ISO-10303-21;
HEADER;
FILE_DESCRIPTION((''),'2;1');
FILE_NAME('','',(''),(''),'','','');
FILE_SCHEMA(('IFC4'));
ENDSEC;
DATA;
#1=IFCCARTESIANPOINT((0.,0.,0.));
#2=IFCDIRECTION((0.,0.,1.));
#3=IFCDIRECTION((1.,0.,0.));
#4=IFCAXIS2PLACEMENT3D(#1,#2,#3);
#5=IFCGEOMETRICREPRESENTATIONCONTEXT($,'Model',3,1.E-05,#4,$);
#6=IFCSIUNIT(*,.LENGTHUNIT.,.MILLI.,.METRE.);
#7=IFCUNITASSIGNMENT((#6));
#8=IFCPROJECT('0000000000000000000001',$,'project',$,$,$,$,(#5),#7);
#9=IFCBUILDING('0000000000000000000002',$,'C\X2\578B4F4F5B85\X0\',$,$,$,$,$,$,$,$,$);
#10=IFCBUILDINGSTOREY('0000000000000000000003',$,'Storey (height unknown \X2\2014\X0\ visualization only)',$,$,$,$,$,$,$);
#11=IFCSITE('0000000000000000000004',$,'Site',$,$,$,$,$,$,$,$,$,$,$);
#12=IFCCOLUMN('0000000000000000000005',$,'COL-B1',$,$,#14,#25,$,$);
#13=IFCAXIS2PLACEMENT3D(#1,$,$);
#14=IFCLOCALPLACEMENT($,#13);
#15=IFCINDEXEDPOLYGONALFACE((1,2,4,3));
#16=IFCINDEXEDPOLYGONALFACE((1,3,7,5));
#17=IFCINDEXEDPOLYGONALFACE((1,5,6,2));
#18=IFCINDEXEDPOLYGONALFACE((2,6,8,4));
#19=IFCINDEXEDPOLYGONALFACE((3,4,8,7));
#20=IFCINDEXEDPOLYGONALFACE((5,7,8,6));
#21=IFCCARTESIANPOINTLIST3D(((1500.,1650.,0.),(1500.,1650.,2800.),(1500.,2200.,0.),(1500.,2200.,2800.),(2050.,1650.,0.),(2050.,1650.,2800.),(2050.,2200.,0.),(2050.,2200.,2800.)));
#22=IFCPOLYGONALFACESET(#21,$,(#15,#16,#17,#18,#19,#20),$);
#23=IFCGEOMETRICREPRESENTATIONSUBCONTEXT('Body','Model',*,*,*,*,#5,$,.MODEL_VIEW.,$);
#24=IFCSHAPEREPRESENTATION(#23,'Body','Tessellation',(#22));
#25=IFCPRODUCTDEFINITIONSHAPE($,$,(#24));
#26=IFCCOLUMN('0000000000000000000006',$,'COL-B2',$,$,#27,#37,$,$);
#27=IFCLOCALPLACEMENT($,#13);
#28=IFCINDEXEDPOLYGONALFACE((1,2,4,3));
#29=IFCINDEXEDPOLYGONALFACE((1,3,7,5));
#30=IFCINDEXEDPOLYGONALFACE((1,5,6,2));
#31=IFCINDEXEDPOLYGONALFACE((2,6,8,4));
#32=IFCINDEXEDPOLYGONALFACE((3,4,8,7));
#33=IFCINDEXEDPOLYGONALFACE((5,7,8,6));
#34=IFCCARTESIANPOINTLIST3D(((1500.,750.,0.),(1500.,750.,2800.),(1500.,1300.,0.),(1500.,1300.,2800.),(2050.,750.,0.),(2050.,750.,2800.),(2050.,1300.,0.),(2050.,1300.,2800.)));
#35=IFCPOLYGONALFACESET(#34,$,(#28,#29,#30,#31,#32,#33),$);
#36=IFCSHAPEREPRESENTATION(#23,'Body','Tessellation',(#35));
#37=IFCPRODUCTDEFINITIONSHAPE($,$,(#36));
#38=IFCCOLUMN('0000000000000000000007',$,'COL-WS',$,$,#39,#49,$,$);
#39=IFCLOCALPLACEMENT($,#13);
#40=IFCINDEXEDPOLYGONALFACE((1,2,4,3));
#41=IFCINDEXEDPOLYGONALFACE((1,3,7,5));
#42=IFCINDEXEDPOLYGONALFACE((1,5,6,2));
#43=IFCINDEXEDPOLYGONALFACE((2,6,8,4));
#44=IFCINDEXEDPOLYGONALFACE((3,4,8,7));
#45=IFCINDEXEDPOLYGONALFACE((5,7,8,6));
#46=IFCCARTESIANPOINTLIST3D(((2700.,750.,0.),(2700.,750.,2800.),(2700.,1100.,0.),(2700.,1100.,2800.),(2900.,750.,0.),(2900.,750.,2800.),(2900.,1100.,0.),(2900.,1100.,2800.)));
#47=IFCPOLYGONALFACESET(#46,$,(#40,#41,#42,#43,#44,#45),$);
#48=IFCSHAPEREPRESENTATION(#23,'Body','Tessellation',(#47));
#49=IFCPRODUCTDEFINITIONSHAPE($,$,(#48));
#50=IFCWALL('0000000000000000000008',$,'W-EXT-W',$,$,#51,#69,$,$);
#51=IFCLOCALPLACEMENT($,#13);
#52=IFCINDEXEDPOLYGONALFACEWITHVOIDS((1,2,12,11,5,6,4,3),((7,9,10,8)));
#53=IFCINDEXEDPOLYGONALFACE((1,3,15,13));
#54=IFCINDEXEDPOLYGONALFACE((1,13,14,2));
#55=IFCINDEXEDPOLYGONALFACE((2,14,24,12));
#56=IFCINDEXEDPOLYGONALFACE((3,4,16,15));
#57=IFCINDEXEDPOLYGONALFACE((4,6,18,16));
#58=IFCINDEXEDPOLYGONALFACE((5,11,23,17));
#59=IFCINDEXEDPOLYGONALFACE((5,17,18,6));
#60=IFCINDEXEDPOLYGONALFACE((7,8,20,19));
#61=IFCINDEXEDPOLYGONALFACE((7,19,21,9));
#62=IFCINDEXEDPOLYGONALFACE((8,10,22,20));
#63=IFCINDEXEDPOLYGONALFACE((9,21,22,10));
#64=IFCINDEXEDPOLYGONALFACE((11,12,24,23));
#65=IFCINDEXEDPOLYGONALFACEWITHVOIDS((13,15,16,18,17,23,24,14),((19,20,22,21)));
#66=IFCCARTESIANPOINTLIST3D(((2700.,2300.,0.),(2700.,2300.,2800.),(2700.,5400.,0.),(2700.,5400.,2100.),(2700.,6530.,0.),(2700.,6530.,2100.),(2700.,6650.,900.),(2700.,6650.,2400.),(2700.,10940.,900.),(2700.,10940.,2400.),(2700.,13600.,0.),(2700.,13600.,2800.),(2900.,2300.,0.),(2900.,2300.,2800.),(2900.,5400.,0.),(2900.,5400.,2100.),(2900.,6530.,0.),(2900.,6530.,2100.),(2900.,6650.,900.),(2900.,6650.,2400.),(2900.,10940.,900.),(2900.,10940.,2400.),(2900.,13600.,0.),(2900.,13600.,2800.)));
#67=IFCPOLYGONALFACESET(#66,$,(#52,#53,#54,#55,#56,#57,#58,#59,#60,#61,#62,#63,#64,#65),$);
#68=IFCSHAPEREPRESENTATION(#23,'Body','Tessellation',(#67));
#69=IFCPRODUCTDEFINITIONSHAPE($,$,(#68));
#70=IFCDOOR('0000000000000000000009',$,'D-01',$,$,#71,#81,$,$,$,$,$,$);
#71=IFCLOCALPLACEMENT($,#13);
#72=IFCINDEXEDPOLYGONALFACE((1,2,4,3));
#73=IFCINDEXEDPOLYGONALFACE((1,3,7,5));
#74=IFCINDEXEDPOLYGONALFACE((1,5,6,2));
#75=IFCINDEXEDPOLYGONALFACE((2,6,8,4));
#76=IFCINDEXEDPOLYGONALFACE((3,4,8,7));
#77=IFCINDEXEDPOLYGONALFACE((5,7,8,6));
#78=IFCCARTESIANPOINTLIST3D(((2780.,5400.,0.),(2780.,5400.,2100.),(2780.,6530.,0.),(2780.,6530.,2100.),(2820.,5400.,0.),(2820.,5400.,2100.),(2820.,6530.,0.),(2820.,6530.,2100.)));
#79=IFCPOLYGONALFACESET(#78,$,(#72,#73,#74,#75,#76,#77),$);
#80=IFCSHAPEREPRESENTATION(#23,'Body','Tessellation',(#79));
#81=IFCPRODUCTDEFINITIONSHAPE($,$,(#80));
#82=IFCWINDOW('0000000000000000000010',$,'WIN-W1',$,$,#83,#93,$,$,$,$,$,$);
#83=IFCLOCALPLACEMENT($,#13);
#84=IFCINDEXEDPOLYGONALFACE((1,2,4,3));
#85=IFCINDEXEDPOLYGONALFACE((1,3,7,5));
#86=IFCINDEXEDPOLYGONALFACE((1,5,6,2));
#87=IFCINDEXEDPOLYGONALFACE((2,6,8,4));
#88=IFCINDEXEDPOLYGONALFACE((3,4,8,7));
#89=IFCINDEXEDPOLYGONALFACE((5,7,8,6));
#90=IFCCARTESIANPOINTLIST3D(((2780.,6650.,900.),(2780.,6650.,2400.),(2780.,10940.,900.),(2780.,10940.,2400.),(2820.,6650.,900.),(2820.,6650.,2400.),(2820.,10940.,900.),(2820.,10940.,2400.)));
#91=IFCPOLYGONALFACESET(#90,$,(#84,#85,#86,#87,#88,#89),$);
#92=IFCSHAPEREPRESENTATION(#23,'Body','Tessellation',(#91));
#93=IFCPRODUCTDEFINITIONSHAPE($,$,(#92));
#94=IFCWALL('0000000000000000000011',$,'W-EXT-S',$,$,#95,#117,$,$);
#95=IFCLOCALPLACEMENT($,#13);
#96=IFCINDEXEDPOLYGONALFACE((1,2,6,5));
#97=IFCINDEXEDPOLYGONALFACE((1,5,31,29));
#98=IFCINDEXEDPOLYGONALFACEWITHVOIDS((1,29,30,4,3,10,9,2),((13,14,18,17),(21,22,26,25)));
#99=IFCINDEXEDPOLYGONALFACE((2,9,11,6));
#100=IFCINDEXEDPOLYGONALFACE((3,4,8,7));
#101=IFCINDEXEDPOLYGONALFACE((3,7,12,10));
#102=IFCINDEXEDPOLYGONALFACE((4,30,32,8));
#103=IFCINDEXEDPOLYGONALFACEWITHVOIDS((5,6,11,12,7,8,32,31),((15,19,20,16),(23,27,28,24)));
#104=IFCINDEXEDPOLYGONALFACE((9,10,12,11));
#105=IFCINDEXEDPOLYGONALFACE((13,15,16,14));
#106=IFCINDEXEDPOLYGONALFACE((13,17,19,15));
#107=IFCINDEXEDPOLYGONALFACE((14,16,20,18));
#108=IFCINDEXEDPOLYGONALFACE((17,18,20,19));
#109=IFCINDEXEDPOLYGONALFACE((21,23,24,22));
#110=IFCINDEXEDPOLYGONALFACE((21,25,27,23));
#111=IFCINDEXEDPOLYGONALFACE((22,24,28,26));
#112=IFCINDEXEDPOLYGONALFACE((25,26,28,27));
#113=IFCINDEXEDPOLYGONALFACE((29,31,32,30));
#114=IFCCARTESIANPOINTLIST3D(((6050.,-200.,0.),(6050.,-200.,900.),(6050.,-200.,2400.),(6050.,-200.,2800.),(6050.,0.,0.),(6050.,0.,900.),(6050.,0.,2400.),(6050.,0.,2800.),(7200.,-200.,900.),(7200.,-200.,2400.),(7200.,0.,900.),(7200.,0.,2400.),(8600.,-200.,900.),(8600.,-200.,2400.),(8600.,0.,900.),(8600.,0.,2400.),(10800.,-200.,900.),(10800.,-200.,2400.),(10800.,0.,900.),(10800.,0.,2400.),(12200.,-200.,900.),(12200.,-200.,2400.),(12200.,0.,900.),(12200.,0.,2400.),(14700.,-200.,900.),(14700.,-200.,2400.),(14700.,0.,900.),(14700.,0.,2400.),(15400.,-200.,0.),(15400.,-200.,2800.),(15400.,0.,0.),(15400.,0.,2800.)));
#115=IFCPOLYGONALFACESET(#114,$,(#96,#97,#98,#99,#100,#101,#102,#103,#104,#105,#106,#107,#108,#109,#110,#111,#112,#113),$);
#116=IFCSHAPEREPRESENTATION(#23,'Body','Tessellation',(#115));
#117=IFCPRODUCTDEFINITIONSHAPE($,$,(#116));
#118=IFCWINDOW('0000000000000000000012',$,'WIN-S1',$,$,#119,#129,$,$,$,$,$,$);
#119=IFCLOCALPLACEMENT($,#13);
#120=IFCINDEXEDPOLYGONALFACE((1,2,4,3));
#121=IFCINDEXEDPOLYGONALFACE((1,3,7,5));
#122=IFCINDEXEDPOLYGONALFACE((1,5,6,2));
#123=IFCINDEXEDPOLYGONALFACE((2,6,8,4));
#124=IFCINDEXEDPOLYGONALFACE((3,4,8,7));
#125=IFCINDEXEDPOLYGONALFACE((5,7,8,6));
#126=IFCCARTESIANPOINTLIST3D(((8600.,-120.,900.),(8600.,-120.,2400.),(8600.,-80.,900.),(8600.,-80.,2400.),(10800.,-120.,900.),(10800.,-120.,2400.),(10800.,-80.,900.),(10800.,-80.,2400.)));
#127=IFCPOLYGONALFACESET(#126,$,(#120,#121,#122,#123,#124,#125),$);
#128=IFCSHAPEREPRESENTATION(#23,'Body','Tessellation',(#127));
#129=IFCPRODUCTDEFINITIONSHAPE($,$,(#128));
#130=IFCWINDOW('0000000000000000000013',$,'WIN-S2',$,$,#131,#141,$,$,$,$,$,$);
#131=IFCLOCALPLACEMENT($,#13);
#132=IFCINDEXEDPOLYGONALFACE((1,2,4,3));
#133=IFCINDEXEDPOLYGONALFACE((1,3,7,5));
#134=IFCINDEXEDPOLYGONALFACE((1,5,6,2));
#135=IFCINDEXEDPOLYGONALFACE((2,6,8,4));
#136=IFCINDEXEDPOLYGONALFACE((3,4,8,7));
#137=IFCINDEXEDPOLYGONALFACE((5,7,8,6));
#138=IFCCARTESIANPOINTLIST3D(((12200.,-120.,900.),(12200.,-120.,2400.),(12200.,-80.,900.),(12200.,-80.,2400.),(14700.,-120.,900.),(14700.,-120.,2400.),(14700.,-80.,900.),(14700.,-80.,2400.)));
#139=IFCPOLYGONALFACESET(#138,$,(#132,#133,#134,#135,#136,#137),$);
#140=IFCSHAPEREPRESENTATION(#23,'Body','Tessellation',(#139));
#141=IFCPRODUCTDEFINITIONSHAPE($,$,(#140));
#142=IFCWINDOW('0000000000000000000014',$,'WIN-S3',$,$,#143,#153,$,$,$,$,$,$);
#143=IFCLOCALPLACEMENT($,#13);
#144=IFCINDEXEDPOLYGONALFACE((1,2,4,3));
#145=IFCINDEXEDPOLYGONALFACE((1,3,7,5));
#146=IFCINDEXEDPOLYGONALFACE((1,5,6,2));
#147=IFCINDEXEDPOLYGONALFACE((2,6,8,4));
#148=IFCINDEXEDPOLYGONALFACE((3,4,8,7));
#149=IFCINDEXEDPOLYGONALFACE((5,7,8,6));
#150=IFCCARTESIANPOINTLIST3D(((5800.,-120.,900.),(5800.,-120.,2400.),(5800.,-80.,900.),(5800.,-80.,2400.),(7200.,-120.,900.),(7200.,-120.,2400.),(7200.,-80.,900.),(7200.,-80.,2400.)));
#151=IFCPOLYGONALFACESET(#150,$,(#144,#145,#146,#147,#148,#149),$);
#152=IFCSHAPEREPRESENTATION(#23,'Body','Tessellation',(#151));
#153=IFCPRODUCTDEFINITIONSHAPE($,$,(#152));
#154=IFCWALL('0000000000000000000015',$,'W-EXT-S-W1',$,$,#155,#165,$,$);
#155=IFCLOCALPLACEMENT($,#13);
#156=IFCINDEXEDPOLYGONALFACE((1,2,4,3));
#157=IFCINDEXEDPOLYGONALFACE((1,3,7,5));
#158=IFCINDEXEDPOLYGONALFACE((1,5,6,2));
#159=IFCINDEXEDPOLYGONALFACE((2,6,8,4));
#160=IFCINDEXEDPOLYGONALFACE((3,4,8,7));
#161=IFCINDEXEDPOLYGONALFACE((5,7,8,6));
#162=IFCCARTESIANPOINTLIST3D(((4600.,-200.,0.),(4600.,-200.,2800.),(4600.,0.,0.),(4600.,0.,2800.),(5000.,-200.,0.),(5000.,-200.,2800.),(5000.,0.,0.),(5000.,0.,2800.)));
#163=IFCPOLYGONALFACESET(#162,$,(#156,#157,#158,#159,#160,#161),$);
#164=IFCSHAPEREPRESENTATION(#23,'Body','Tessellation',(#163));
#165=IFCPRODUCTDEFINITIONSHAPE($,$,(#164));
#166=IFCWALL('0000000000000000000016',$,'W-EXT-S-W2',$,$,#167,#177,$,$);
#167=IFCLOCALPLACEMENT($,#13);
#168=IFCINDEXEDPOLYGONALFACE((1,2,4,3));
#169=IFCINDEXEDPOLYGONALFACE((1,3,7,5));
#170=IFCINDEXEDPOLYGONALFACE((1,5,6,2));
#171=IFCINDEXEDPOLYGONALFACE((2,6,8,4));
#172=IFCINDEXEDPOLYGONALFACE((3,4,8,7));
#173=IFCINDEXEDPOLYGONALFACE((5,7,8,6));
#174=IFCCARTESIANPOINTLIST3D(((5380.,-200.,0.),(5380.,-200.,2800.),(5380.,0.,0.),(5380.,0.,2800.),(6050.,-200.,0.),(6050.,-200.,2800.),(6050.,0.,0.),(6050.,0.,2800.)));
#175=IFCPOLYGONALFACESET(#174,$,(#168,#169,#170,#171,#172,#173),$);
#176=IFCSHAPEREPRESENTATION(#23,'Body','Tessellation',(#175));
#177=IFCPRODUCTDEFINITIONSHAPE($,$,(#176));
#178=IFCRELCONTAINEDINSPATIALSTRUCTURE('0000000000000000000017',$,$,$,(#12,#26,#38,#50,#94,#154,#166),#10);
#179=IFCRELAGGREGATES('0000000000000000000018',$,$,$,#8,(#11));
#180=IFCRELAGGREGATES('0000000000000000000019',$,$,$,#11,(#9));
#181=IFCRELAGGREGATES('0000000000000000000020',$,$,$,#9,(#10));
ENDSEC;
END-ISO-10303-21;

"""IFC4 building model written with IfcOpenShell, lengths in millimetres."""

from ifc_helpers import new_model, si_unit, frame, frame_2d, origin_with_axes, place, context, subcontext, project, spatial, rectangle, extrude, element, fill, save


model = new_model("IFC4")

# Units and contexts
model_context = context("Model", 3, precision=1e-05, world=origin_with_axes())
body_context = subcontext(model_context, "Body", "Model", "MODEL_VIEW")
ifc_project = project(units=[si_unit("LENGTHUNIT", "METRE", prefix="MILLI")], contexts=[model_context])

# Site, building, storey
site = spatial("IfcSite", under=ifc_project, Name="Site")
building = spatial("IfcBuilding", under=site, Name="C型住宅")
storey = spatial("IfcBuildingStorey", under=building, Name="Storey (height unknown — visualization only)")

# Columns
for number, where, z_axis, x_axis, name in (
    (1, (1500.0, 1650.0, 0.0), (0.0, 0.0, 1.0), (1.0, 0.0, 0.0), "COL-B1"),
    (2, (1500.0, 750.0, 0.0), (0.0, 0.0, 1.0), (1.0, 0.0, 0.0), "COL-B2"),
):
    element("IfcColumn", number, at=place(None, frame(where, z_axis=z_axis, x_axis=x_axis)), inside=storey, Name=name, context=body_context, shape_type="SweptSolid", body=[
        extrude(rectangle(XDim=550.0, YDim=550.0, at=frame_2d((275.0, 275.0))), origin_with_axes(), (0.0, 0.0, 1.0), 2800.0),
    ])
column_placement = place(None, frame((2700.0, 750.0, 0.0), z_axis=(0.0, 0.0, 1.0), x_axis=(1.0, 0.0, 0.0)))
element("IfcColumn", 3, at=column_placement, inside=storey, Name="COL-WS", context=body_context, shape_type="SweptSolid", body=[
    extrude(rectangle(XDim=200.0, YDim=350.0, at=frame_2d((100.0, 175.0))), origin_with_axes(), (0.0, 0.0, 1.0), 2800.0),
])

# Wall, openings, door, window
wall_1_placement = place(None, frame((2700.0, 2300.0, 0.0), z_axis=(0.0, 0.0, 1.0), x_axis=(1.0, 0.0, 0.0)))
wall_1 = element("IfcWall", 4, at=wall_1_placement, inside=storey, Name="W-EXT-W", context=body_context, shape_type="SweptSolid", body=[
    extrude(rectangle(XDim=200.0, YDim=11300.0, at=frame_2d((100.0, 5650.0))), origin_with_axes(), (0.0, 0.0, 1.0), 2800.0),
])
opening_1_placement = place(wall_1_placement, frame((0.0, 3100.0, 0.0)))
opening_1 = element("IfcOpeningElement", 5, at=opening_1_placement, cuts=wall_1, context=body_context, shape_type="SweptSolid", body=[
    extrude(rectangle(XDim=200.0, YDim=1130.0, at=frame_2d((100.0, 565.0))), origin_with_axes(), (0.0, 0.0, 1.0), 2100.0),
])
opening_2_placement = place(wall_1_placement, frame((0.0, 4350.0, 900.0)))
opening_2 = element("IfcOpeningElement", 6, at=opening_2_placement, cuts=wall_1, context=body_context, shape_type="SweptSolid", body=[
    extrude(rectangle(XDim=200.0, YDim=4290.0, at=frame_2d((100.0, 2145.0))), origin_with_axes(), (0.0, 0.0, 1.0), 1500.0),
])
door_1_placement = place(wall_1_placement, frame((80.0, 3100.0, 0.0)))
door_1 = element("IfcDoor", 7, at=door_1_placement, Name="D-01", context=body_context, shape_type="SweptSolid", body=[
    extrude(rectangle(XDim=40.0, YDim=1130.0, at=frame_2d((20.0, 565.0))), origin_with_axes(), (0.0, 0.0, 1.0), 2100.0),
])
fill(opening_1, door_1)
window_1_placement = place(wall_1_placement, frame((80.0, 4350.0, 900.0)))
window_1 = element("IfcWindow", 8, at=window_1_placement, Name="WIN-W1", context=body_context, shape_type="SweptSolid", body=[
    extrude(rectangle(XDim=40.0, YDim=4290.0, at=frame_2d((20.0, 2145.0))), origin_with_axes(), (0.0, 0.0, 1.0), 1500.0),
])
fill(opening_2, window_1)

# Wall, openings, windows
wall_2_placement = place(None, frame((6050.0, -200.0, 0.0), z_axis=(0.0, 0.0, 1.0), x_axis=(1.0, 0.0, 0.0)))
wall_2 = element("IfcWall", 9, at=wall_2_placement, inside=storey, Name="W-EXT-S", context=body_context, shape_type="SweptSolid", body=[
    extrude(rectangle(XDim=9350.0, YDim=200.0, at=frame_2d((4675.0, 100.0))), origin_with_axes(), (0.0, 0.0, 1.0), 2800.0),
])
opening_3_placement = place(wall_2_placement, frame((2550.0, 0.0, 900.0)))
opening_3 = element("IfcOpeningElement", 10, at=opening_3_placement, cuts=wall_2, context=body_context, shape_type="SweptSolid", body=[
    extrude(rectangle(XDim=2200.0, YDim=200.0, at=frame_2d((1100.0, 100.0))), origin_with_axes(), (0.0, 0.0, 1.0), 1500.0),
])
opening_4_placement = place(wall_2_placement, frame((6150.0, 0.0, 900.0)))
opening_4 = element("IfcOpeningElement", 11, at=opening_4_placement, cuts=wall_2, context=body_context, shape_type="SweptSolid", body=[
    extrude(rectangle(XDim=2500.0, YDim=200.0, at=frame_2d((1250.0, 100.0))), origin_with_axes(), (0.0, 0.0, 1.0), 1500.0),
])
opening_5_placement = place(wall_2_placement, frame((-250.0, 0.0, 900.0)))
opening_5 = element("IfcOpeningElement", 12, at=opening_5_placement, cuts=wall_2, context=body_context, shape_type="SweptSolid", body=[
    extrude(rectangle(XDim=1400.0, YDim=200.0, at=frame_2d((700.0, 100.0))), origin_with_axes(), (0.0, 0.0, 1.0), 1500.0),
])
window_2_placement = place(wall_2_placement, frame((2550.0, 80.0, 900.0)))
window_2 = element("IfcWindow", 13, at=window_2_placement, Name="WIN-S1", context=body_context, shape_type="SweptSolid", body=[
    extrude(rectangle(XDim=2200.0, YDim=40.0, at=frame_2d((1100.0, 20.0))), origin_with_axes(), (0.0, 0.0, 1.0), 1500.0),
])
fill(opening_3, window_2)
window_3_placement = place(wall_2_placement, frame((6150.0, 80.0, 900.0)))
window_3 = element("IfcWindow", 14, at=window_3_placement, Name="WIN-S2", context=body_context, shape_type="SweptSolid", body=[
    extrude(rectangle(XDim=2500.0, YDim=40.0, at=frame_2d((1250.0, 20.0))), origin_with_axes(), (0.0, 0.0, 1.0), 1500.0),
])
fill(opening_4, window_3)
window_4_placement = place(wall_2_placement, frame((-250.0, 80.0, 900.0)))
window_4 = element("IfcWindow", 15, at=window_4_placement, Name="WIN-S3", context=body_context, shape_type="SweptSolid", body=[
    extrude(rectangle(XDim=1400.0, YDim=40.0, at=frame_2d((700.0, 20.0))), origin_with_axes(), (0.0, 0.0, 1.0), 1500.0),
])
fill(opening_5, window_4)

# Walls
wall_3_placement = place(None, frame((4600.0, -200.0, 0.0), z_axis=(0.0, 0.0, 1.0), x_axis=(1.0, 0.0, 0.0)))
element("IfcWall", 16, at=wall_3_placement, inside=storey, Name="W-EXT-S-W1", context=body_context, shape_type="SweptSolid", body=[
    extrude(rectangle(XDim=400.0, YDim=200.0, at=frame_2d((200.0, 100.0))), origin_with_axes(), (0.0, 0.0, 1.0), 2800.0),
])
wall_4_placement = place(None, frame((5380.0, -200.0, 0.0), z_axis=(0.0, 0.0, 1.0), x_axis=(1.0, 0.0, 0.0)))
element("IfcWall", 17, at=wall_4_placement, inside=storey, Name="W-EXT-S-W2", context=body_context, shape_type="SweptSolid", body=[
    extrude(rectangle(XDim=670.0, YDim=200.0, at=frame_2d((335.0, 100.0))), origin_with_axes(), (0.0, 0.0, 1.0), 2800.0),
])

save(model, "model.ifc")
